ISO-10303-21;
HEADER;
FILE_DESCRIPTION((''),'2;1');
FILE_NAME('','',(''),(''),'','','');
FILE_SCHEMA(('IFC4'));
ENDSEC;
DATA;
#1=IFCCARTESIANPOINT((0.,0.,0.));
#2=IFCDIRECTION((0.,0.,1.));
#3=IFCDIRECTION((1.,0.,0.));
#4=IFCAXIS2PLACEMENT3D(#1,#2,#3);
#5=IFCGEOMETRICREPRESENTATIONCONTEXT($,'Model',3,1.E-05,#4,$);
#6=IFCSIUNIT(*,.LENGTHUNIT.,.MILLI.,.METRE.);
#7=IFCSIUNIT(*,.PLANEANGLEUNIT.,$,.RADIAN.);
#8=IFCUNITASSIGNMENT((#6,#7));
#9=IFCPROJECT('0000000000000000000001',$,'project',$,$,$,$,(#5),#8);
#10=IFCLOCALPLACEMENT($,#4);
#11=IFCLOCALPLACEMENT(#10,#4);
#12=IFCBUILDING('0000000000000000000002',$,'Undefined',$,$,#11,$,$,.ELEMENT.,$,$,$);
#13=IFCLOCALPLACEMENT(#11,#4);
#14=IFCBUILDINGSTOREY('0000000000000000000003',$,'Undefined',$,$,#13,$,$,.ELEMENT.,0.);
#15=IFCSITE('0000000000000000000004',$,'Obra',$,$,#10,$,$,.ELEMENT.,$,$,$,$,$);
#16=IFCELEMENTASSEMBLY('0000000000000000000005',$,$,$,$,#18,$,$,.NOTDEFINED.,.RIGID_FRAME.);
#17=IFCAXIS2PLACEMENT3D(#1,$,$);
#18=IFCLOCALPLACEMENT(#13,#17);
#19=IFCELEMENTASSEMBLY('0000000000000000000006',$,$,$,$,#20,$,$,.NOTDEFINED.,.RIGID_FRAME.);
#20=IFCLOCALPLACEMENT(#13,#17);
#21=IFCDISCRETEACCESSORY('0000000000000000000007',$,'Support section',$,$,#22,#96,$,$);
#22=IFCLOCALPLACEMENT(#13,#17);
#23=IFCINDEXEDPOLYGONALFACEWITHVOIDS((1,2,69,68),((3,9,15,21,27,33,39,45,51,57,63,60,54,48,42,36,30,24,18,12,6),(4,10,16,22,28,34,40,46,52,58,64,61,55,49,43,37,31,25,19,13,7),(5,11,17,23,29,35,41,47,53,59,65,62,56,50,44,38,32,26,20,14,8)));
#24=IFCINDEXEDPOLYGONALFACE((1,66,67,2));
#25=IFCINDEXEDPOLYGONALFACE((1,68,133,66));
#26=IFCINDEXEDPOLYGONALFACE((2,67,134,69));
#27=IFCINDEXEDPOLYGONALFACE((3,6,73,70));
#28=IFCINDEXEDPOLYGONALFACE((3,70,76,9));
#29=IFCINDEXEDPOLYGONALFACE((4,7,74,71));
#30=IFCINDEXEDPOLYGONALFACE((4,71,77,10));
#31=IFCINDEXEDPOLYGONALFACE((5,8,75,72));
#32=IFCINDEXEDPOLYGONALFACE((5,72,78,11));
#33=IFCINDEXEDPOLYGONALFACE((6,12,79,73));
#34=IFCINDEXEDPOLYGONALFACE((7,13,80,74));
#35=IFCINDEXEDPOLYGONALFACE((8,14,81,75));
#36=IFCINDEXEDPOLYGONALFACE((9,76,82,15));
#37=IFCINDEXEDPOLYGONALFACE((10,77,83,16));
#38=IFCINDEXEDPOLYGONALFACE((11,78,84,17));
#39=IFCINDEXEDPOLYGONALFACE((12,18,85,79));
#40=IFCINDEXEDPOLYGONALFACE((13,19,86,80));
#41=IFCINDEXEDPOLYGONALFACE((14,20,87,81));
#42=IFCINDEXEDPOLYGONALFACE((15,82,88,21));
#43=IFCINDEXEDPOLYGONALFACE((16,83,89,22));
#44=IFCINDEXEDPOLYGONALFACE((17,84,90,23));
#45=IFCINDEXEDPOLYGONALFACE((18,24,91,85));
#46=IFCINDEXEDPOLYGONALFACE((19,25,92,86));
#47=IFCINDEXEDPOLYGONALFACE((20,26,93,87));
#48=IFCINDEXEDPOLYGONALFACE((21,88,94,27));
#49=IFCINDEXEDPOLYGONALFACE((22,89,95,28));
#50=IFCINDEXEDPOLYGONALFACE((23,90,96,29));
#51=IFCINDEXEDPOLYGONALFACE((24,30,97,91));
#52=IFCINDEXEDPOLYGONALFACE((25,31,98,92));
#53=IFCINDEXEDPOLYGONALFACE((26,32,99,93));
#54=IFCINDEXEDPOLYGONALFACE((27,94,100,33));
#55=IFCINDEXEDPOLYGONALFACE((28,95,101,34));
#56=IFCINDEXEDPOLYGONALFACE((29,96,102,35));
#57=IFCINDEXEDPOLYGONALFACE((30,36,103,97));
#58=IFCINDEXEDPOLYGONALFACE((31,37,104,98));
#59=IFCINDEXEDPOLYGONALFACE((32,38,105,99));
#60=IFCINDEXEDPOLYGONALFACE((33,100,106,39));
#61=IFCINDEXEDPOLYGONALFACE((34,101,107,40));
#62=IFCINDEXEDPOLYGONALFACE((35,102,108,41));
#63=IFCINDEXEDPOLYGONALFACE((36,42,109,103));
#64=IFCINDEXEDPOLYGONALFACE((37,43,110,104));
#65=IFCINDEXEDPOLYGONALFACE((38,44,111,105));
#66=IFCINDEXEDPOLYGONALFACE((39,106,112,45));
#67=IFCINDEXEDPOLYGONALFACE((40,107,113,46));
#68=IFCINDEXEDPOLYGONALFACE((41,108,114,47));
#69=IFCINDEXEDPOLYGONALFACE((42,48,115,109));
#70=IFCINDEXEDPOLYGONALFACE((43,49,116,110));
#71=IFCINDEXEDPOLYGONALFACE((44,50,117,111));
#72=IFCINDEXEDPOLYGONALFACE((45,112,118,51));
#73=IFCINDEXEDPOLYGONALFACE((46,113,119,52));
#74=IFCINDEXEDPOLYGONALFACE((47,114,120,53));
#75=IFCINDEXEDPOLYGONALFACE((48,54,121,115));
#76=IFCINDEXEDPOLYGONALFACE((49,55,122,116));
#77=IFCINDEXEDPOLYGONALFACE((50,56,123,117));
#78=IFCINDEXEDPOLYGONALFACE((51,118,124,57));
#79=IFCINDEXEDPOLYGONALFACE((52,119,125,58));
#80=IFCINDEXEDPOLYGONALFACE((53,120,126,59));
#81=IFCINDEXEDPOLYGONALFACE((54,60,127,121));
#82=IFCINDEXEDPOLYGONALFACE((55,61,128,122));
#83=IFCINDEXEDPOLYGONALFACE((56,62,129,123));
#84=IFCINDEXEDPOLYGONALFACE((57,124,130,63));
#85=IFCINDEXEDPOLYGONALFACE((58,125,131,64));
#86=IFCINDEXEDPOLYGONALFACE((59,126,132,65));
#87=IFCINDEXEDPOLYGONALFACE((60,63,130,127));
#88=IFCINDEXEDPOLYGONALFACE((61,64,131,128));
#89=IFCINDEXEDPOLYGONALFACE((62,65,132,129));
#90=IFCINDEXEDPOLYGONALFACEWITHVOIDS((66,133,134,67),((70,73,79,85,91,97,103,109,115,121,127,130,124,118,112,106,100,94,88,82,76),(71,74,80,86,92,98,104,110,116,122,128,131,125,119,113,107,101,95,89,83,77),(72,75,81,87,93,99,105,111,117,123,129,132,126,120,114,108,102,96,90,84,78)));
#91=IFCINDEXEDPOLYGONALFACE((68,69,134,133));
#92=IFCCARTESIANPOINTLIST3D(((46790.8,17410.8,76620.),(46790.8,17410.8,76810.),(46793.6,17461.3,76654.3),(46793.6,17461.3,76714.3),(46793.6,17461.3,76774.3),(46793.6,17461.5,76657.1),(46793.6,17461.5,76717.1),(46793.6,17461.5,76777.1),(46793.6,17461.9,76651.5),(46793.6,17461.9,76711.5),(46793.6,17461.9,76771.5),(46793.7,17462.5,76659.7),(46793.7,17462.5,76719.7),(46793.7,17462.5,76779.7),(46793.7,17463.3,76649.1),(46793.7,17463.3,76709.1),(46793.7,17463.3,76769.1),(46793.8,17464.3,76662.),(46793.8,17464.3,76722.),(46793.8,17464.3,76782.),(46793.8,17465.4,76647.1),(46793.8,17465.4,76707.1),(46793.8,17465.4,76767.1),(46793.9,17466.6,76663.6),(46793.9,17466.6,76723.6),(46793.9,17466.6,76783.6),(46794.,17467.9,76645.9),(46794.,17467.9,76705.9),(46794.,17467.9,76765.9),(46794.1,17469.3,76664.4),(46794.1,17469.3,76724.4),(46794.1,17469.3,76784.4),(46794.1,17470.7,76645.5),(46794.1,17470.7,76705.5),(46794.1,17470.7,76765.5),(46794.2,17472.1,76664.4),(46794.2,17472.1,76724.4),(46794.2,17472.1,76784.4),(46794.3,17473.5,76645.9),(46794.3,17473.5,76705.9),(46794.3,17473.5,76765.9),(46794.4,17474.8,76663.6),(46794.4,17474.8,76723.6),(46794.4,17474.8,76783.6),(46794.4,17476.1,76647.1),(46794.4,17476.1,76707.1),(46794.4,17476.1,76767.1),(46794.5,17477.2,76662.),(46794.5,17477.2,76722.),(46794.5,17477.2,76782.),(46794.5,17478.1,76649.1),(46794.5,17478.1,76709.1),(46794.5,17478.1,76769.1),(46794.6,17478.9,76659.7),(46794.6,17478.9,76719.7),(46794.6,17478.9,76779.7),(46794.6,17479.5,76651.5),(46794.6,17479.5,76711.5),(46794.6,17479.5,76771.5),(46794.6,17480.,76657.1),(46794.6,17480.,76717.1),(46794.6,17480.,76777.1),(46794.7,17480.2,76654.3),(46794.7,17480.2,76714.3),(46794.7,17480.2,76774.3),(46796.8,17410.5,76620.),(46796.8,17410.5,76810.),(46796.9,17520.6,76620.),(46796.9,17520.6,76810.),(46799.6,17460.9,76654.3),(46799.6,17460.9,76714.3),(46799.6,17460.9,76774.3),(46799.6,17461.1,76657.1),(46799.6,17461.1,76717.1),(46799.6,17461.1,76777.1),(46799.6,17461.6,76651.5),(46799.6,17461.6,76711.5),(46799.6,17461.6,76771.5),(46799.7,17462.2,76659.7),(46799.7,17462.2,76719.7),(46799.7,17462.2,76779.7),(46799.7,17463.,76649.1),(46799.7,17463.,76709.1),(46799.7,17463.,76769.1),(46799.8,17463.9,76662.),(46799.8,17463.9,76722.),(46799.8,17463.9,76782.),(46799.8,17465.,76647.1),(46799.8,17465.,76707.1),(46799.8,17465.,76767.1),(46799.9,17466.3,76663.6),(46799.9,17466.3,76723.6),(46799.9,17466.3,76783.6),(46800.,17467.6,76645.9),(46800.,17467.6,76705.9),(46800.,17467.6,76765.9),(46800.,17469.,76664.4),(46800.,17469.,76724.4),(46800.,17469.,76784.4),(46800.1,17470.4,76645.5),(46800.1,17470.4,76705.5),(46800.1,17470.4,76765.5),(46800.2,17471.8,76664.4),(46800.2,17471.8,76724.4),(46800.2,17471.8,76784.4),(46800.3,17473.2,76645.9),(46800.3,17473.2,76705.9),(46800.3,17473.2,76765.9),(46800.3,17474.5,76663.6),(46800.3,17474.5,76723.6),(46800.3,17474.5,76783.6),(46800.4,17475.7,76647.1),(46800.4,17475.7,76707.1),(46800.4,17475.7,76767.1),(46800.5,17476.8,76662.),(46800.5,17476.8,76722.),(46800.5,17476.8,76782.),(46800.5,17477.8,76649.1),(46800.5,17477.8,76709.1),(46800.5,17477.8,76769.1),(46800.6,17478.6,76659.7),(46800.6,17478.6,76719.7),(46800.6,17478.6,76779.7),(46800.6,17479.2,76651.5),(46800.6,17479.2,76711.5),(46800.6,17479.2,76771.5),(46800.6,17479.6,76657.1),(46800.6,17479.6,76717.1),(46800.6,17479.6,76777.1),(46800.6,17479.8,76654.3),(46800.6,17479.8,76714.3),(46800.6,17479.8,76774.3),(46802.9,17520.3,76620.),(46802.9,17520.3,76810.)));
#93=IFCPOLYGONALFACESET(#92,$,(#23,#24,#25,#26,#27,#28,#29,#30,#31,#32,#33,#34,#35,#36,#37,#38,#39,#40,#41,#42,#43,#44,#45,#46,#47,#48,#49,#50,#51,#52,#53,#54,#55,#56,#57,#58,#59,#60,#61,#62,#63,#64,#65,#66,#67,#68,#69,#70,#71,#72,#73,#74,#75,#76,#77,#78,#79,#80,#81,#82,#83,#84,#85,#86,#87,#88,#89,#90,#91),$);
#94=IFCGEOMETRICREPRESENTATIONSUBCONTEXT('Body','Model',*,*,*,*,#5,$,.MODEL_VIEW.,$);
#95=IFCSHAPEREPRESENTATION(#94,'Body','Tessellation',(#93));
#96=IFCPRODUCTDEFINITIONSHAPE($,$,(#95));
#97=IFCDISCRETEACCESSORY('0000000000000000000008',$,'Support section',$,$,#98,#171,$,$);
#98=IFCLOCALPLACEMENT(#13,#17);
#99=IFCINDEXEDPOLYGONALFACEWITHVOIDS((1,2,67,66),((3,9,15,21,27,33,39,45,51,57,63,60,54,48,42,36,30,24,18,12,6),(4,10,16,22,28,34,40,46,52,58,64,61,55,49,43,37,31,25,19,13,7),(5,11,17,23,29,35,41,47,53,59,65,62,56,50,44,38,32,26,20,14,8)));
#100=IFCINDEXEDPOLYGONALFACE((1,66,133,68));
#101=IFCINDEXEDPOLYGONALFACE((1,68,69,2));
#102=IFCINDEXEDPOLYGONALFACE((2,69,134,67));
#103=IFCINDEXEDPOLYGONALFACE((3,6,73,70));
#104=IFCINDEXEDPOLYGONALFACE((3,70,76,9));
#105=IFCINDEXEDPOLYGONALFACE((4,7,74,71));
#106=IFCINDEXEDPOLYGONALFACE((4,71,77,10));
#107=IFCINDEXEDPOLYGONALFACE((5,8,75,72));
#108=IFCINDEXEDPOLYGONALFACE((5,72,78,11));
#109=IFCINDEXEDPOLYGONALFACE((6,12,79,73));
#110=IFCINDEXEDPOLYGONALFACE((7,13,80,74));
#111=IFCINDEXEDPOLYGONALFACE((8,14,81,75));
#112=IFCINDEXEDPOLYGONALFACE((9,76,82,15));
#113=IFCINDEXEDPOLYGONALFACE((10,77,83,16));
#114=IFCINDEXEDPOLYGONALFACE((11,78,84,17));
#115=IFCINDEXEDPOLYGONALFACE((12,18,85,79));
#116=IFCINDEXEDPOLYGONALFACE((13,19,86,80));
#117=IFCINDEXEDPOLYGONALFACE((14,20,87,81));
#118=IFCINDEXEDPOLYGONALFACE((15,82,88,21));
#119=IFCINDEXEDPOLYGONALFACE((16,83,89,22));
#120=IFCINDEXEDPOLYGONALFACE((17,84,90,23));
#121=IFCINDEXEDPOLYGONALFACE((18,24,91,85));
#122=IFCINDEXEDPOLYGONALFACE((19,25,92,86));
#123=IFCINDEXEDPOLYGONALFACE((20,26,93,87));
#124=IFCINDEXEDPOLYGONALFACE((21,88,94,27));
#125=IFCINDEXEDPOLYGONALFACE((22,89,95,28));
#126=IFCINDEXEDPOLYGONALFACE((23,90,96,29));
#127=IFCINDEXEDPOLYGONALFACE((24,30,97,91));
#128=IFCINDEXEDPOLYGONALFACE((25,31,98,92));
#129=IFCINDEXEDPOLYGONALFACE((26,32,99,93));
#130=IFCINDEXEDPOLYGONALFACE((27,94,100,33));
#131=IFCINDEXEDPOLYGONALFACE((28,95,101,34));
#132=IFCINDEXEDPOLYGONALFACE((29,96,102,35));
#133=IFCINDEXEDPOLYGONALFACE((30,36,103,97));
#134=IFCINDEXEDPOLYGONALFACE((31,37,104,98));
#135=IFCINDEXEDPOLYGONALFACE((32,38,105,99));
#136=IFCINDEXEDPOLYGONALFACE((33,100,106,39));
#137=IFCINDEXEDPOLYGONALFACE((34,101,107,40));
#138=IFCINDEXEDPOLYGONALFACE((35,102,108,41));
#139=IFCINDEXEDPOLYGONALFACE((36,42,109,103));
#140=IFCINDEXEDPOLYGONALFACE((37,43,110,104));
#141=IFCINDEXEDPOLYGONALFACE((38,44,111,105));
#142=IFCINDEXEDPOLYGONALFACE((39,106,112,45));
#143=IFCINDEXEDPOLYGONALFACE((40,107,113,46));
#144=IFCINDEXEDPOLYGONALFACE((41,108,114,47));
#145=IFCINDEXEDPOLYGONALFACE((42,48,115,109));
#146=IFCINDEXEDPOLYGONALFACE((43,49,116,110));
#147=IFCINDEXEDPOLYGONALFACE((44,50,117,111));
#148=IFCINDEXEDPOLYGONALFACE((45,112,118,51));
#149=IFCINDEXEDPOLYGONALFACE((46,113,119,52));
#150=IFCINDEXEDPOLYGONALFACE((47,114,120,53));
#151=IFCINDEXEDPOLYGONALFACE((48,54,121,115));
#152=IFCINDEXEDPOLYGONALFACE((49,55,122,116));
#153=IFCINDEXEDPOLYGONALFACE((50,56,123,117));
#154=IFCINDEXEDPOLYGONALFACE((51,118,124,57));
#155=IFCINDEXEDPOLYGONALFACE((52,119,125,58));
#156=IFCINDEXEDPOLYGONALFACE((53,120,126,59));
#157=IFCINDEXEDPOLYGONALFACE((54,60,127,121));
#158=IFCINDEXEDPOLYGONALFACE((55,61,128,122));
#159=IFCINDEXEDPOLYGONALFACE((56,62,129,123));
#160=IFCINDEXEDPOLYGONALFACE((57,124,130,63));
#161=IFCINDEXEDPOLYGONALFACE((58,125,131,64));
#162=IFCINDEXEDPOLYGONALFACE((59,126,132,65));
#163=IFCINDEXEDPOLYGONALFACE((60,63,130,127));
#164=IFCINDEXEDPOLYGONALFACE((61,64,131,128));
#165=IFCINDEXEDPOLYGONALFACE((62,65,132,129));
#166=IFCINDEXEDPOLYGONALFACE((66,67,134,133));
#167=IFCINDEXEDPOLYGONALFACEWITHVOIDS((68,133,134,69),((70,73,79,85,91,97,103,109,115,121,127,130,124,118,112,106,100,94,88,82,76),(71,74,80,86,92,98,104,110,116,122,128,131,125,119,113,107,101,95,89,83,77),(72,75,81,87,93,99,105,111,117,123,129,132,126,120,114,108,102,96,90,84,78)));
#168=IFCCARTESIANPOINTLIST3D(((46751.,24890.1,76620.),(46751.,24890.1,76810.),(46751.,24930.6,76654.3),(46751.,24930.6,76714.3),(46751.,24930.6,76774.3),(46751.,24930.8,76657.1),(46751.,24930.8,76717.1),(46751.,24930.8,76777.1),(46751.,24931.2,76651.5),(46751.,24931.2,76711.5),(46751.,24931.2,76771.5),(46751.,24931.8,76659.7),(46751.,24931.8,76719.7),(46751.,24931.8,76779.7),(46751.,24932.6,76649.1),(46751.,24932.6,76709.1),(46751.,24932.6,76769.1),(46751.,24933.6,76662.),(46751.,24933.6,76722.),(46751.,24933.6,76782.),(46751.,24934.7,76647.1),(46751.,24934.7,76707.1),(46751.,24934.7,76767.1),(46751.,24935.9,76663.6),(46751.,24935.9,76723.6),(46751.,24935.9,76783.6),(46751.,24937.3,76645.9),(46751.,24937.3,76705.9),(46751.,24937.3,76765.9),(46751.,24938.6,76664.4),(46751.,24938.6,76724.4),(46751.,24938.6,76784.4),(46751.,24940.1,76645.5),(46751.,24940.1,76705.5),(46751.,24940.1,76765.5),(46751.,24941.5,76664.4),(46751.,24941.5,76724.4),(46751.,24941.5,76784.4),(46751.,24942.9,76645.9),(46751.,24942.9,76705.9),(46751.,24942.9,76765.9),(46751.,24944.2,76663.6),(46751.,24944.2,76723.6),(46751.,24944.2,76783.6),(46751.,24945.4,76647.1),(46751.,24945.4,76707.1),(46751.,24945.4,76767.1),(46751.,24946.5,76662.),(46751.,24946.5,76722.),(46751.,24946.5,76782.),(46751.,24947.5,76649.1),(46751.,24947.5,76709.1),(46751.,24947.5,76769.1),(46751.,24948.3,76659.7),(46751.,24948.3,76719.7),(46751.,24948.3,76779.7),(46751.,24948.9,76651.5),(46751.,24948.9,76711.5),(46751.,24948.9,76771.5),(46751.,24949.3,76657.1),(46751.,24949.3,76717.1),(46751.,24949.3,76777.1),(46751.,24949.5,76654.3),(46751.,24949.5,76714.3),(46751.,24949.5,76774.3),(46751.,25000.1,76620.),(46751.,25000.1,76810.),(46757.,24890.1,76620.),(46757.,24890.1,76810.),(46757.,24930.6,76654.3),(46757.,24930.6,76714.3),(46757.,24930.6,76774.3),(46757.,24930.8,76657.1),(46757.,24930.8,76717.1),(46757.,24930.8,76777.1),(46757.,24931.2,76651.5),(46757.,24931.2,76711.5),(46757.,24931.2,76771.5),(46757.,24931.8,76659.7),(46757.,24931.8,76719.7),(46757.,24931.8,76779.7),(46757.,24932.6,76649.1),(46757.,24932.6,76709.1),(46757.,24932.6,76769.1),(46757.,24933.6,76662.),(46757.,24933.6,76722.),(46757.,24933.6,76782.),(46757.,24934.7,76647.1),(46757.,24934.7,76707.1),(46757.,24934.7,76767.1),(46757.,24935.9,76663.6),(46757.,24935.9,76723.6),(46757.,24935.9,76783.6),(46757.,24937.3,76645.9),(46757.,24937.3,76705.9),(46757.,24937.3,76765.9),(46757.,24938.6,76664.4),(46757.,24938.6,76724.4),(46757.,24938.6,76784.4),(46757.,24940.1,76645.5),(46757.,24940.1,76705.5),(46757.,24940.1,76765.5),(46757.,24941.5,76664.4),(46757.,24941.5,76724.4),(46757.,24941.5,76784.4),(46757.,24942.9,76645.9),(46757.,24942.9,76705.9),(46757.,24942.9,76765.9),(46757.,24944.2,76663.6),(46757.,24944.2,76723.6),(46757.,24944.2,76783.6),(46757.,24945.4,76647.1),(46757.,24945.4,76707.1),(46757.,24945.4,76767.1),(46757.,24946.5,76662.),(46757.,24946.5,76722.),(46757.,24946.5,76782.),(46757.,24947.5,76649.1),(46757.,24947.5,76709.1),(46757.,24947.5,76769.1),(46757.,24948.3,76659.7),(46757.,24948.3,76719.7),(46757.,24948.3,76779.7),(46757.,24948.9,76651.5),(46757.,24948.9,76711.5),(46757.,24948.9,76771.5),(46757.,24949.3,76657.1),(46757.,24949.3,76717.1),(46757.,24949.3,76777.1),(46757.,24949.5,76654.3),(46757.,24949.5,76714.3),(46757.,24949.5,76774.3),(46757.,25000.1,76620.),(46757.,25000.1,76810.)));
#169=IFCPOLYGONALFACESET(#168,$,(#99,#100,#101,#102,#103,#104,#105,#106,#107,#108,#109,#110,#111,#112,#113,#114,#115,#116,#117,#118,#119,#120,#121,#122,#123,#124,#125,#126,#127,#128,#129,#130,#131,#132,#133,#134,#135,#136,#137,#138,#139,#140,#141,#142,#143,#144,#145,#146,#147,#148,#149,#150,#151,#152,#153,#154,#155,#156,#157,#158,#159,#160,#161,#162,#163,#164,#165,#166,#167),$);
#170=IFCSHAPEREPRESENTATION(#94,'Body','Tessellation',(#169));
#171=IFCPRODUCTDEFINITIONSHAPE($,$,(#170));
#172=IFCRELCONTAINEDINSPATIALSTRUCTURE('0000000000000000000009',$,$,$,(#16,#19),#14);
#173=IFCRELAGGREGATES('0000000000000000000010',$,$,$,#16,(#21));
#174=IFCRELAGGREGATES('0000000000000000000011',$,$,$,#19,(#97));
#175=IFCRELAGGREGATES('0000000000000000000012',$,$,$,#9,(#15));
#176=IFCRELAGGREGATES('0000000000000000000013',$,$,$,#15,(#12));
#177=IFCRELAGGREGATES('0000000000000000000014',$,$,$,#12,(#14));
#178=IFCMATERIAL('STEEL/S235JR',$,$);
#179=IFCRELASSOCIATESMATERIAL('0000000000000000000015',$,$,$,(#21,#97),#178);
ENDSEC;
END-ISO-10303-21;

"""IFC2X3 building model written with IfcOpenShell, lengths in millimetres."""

from ifc_helpers import new_model, si_unit, frame, origin_with_axes, origin_2d_with_axis, place, context, subcontext, project, spatial, rectangle, circle, extrude, source, transform, mapped, material, element, aggregate, save


model = new_model("IFC2X3")

# Units and contexts
model_context = context("Model", 3, precision=1e-05, world=origin_with_axes())
body_context = subcontext(model_context, "Body", "Model", "MODEL_VIEW")
ifc_project = project(units=[si_unit("LENGTHUNIT", "METRE", prefix="MILLI"), si_unit("PLANEANGLEUNIT", "RADIAN")], contexts=[model_context])

# Site, building, storey
site_placement = place(None, origin_with_axes())
site = spatial("IfcSite", under=ifc_project, at=site_placement, Name="Obra", CompositionType="ELEMENT")
building_placement = place(site_placement, origin_with_axes())
building = spatial("IfcBuilding", under=site, at=building_placement, Name="Undefined", CompositionType="ELEMENT")
storey_placement = place(building_placement, origin_with_axes())
storey = spatial("IfcBuildingStorey", under=building, at=storey_placement, Name="Undefined", CompositionType="ELEMENT", Elevation=0.0)

# Element assemblies
ifc_material_1 = material(Name="STEEL/S235JR")
assembly_1_placement = place(storey_placement, origin_with_axes())
assembly_1 = element("IfcElementAssembly", 1, at=assembly_1_placement, inside=storey, AssemblyPlace="NOTDEFINED", PredefinedType="RIGID_FRAME")
assembly_2_placement = place(storey_placement, origin_with_axes())
assembly_2 = element("IfcElementAssembly", 2, at=assembly_2_placement, inside=storey, AssemblyPlace="NOTDEFINED", PredefinedType="RIGID_FRAME")

# Discrete accessories, openings
shared_shape = source(origin_with_axes(), body_context, "Body", "SweptSolid", [
    extrude(circle(Radius=9.5, at=origin_2d_with_axis()), frame((0.0, -9.2, 0.0), z_axis=(0.0, 1.0, 0.0), x_axis=(1.0, 0.0, 0.0)), (0.0, 0.0, 1.0), 6.2),
])
discrete_accessory_1_placement = place(assembly_1_placement, frame((46796.9, 17465.6, 76620.0), z_axis=(0.0, 0.0, 1.0), x_axis=(-0.055268, -0.998472, 0.0)))
discrete_accessory_1 = element("IfcDiscreteAccessory", 3, at=discrete_accessory_1_placement, material=ifc_material_1, Name="Support section", context=body_context, shape_type="SweptSolid", body=[
    extrude(rectangle(XDim=6.0, YDim=110.0, at=origin_2d_with_axis()), frame((0.0, 0.0, 190.0), z_axis=(0.0, 0.0, -1.0), x_axis=(0.0, 1.0, 0.0)), (0.0, 0.0, 1.0), 190.0),
])
opening_1_placement = place(assembly_1_placement, frame((46788.3, 17421.0, 76835.0), z_axis=(0.055268, 0.998472, 0.0), x_axis=(0.0, 0.0, -1.0)))
element("IfcOpeningElement", 4, at=opening_1_placement, cuts=discrete_accessory_1, ObjectType="Opening", context=body_context, shape_type="MappedRepresentation", body=[
    mapped(shared_shape, transform((60.0, 0.0, 50.0))),
    mapped(shared_shape, transform((120.0, 0.0, 50.0))),
    mapped(shared_shape, transform((180.0, 0.0, 50.0))),
])
aggregate(assembly_1, [discrete_accessory_1])
discrete_accessory_2_placement = place(assembly_2_placement, frame((46754.0, 24945.1, 76620.0), z_axis=(0.0, 0.0, 1.0), x_axis=(-0.000002, 1.0, 0.0)))
discrete_accessory_2 = element("IfcDiscreteAccessory", 5, at=discrete_accessory_2_placement, material=ifc_material_1, Name="Support section", context=body_context, shape_type="SweptSolid", body=[
    extrude(rectangle(XDim=6.0, YDim=110.0, at=origin_2d_with_axis()), frame((0.0, 0.0, 190.0), z_axis=(0.0, 0.0, -1.0), x_axis=(0.0, 1.0, 0.0)), (0.0, 0.0, 1.0), 190.0),
])
opening_2_placement = place(assembly_2_placement, frame((46760.1, 24990.1, 76835.0), z_axis=(0.000002, -1.0, 0.0), x_axis=(0.0, 0.0, -1.0)))
element("IfcOpeningElement", 6, at=opening_2_placement, cuts=discrete_accessory_2, ObjectType="Opening", context=body_context, shape_type="MappedRepresentation", body=[
    mapped(shared_shape, transform((60.0, 0.0, 50.0))),
    mapped(shared_shape, transform((120.0, 0.0, 50.0))),
    mapped(shared_shape, transform((180.0, 0.0, 50.0))),
])
aggregate(assembly_2, [discrete_accessory_2])

save(model, "model.ifc")
